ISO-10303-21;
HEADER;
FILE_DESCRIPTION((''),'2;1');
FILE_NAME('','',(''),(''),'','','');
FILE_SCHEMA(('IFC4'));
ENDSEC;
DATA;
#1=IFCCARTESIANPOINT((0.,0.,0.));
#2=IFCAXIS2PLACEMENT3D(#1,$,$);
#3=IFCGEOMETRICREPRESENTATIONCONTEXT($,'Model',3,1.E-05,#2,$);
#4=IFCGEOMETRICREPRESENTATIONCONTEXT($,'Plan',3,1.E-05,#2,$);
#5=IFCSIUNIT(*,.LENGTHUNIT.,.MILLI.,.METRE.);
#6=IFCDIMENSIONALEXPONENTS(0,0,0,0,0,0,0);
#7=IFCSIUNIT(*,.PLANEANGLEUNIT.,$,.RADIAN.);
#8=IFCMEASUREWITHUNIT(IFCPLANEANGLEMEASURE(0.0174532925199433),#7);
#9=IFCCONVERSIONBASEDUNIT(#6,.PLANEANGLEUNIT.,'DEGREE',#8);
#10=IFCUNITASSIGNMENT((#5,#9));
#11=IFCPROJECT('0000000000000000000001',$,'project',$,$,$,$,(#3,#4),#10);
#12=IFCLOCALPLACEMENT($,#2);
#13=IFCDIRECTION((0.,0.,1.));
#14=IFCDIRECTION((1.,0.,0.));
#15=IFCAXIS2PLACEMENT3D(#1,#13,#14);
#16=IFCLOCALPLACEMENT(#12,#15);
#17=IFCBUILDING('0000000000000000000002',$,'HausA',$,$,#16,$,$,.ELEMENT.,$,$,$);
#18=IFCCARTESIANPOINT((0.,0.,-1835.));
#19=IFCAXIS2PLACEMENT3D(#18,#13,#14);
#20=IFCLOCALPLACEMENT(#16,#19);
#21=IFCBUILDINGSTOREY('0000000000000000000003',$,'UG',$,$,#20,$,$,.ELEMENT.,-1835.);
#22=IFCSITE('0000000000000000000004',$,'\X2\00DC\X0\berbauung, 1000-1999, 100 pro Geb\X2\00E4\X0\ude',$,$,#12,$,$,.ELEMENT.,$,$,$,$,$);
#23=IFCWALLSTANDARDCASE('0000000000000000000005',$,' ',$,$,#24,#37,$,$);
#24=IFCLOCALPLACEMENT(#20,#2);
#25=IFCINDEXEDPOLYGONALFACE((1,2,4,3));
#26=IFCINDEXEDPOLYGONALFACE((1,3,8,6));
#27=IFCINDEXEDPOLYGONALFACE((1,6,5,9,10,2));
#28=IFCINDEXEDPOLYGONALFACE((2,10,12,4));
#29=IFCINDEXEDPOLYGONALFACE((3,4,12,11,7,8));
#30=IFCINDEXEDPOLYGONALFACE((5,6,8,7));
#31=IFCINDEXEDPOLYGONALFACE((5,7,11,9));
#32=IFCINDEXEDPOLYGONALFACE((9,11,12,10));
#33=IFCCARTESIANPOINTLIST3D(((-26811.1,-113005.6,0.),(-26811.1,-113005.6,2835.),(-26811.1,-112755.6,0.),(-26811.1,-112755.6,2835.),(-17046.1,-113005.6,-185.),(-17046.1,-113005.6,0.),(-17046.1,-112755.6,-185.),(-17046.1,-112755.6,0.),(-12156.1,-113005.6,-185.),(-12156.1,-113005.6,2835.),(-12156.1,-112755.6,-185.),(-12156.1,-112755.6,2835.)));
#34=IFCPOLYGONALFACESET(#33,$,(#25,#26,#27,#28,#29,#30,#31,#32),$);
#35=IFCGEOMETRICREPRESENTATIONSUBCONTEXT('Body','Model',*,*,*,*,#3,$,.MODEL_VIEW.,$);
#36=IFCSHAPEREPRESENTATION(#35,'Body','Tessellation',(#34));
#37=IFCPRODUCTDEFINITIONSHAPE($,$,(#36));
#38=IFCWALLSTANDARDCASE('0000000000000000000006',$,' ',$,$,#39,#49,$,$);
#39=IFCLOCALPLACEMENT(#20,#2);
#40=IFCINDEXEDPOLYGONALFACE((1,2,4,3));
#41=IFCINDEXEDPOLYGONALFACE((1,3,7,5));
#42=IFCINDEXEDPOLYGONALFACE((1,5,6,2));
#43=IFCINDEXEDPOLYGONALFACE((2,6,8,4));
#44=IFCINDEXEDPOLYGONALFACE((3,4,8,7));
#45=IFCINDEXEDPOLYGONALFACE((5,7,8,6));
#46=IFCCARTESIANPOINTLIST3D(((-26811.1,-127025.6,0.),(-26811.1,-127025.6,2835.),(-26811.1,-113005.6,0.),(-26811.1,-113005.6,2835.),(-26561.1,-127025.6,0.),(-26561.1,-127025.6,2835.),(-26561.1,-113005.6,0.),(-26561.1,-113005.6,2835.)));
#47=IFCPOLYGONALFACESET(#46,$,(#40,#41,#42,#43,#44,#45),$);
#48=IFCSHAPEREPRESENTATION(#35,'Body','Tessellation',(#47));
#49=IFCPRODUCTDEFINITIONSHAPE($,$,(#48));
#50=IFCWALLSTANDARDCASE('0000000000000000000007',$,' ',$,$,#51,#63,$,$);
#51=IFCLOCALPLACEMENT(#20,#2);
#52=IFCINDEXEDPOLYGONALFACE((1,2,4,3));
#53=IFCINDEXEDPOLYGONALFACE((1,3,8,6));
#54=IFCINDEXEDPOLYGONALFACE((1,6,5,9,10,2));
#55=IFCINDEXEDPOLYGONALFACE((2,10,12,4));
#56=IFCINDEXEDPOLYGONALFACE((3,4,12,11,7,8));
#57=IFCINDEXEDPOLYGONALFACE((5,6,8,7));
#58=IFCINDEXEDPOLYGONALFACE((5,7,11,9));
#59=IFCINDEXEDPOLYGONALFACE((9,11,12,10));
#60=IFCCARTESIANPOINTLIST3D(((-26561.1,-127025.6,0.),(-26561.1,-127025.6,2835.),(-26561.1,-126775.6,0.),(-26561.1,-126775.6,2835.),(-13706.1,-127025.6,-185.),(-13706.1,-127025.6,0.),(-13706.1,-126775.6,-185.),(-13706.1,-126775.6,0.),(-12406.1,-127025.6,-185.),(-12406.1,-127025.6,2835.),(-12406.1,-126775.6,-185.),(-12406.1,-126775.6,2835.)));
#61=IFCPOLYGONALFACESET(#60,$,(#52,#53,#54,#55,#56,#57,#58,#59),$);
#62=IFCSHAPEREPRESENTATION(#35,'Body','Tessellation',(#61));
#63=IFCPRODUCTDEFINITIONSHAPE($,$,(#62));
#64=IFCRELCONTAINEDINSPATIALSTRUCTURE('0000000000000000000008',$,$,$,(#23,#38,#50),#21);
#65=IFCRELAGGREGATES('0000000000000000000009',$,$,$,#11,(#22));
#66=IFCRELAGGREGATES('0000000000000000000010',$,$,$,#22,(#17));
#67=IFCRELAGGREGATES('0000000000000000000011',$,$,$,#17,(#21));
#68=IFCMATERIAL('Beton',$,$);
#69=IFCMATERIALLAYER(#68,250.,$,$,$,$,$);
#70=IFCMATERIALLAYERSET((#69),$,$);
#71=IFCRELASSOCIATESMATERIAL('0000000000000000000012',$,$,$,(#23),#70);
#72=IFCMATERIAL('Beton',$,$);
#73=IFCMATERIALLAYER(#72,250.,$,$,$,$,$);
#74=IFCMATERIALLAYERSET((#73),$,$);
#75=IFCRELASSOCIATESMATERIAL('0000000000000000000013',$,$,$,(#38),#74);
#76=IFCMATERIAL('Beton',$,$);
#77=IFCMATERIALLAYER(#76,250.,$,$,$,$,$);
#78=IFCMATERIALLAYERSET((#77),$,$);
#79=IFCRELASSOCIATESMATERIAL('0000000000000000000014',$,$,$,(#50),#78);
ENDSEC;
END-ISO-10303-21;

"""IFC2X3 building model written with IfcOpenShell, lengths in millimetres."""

from ifc_helpers import new_model, entity, si_unit, converted_unit, frame, frame_2d, origin, origin_with_axes, place, context, subcontext, project, spatial, polyline, rectangle, extrude, clip, bounded_halfspace, material, layer, layer_set, layer_usage, element, save


model = new_model("IFC2X3")

# Units and contexts
model_context = context("Model", 3, precision=1e-05, world=origin())
plan_context = context("Plan", 3, precision=1e-05, world=origin())
body_context = subcontext(model_context, "Body", "Model", "MODEL_VIEW")
ifc_project = project(units=[si_unit("LENGTHUNIT", "METRE", prefix="MILLI"), converted_unit("PLANEANGLEUNIT", "DEGREE", entity("IfcPlaneAngleMeasure", 0.0174532925199433), si_unit("PLANEANGLEUNIT", "RADIAN"), dimensions=[0, 0, 0, 0, 0, 0, 0])], contexts=[model_context, plan_context])

# Site, building, storey
site_placement = place(None, origin())
site = spatial("IfcSite", under=ifc_project, at=site_placement, Name="Überbauung, 1000-1999, 100 pro Gebäude", CompositionType="ELEMENT")
building_placement = place(site_placement, origin_with_axes())
building = spatial("IfcBuilding", under=site, at=building_placement, Name="HausA", CompositionType="ELEMENT")
storey_placement = place(building_placement, frame((0.0, 0.0, -1835.0), z_axis=(0.0, 0.0, 1.0), x_axis=(1.0, 0.0, 0.0)))
storey = spatial("IfcBuildingStorey", under=building, at=storey_placement, Name="UG", CompositionType="ELEMENT", Elevation=-1835.0)

# Walls
ifc_material_1 = material(Name="Beton")
ifc_layer_1 = layer(ifc_material_1, 250.0)
ifc_layer_set_1 = layer_set([ifc_layer_1])
ifc_layer_usage_1 = layer_usage(ifc_layer_set_1, "AXIS2", "POSITIVE", 0.0)
wall_1_placement = place(storey_placement, frame((-12156.1, -112755.6, -185.0), z_axis=(0.0, 0.0, 1.0), x_axis=(-1.0, 0.0, 0.0)))
element("IfcWallStandardCase", 1, at=wall_1_placement, inside=storey, material=ifc_layer_usage_1, Name=" ", context=body_context, shape_type="Clipping", body=[
    clip(clip(extrude(rectangle(XDim=14655.0, YDim=250.0, at=frame_2d((7327.5, 125.0), x_axis=(1.0, 0.0))), origin_with_axes(), (0.0, 0.0, 1.0), 3020.0), bounded_halfspace(frame((4890.0, 0.0, 0.0), z_axis=(0.0, 0.0, 1.0), x_axis=(0.0, 1.0, 0.0)), True, origin(), polyline([(4890.0, 0.0), (4890.0, 250.0), (0.0, 250.0), (0.0, 0.0), (4890.0, 0.0)]))), bounded_halfspace(frame((14655.0, 250.0, 185.0), z_axis=(0.0, 0.0, 1.0), x_axis=(-1.0, 0.0, 0.0)), True, origin(), polyline([(14655.0, 250.0), (4890.0, 250.0), (4890.0, 0.0), (14655.0, 0.0), (14655.0, 250.0)]))),
])
ifc_material_2 = material(Name="Beton")
ifc_layer_2 = layer(ifc_material_2, 250.0)
ifc_layer_set_2 = layer_set([ifc_layer_2])
ifc_layer_usage_2 = layer_usage(ifc_layer_set_2, "AXIS2", "POSITIVE", 0.0)
wall_2_placement = place(storey_placement, frame((-26811.1, -113005.6, 0.0), z_axis=(0.0, 0.0, 1.0), x_axis=(0.0, -1.0, 0.0)))
element("IfcWallStandardCase", 2, at=wall_2_placement, inside=storey, material=ifc_layer_usage_2, Name=" ", context=body_context, shape_type="SweptSolid", body=[
    extrude(rectangle(XDim=14020.0, YDim=250.0, at=frame_2d((7010.0, 125.0), x_axis=(1.0, 0.0))), origin_with_axes(), (0.0, 0.0, 1.0), 2835.0),
])
ifc_material_3 = material(Name="Beton")
ifc_layer_3 = layer(ifc_material_3, 250.0)
ifc_layer_set_3 = layer_set([ifc_layer_3])
ifc_layer_usage_3 = layer_usage(ifc_layer_set_3, "AXIS2", "POSITIVE", 0.0)
wall_3_placement = place(storey_placement, frame((-26561.1, -127025.6, -185.0), z_axis=(0.0, 0.0, 1.0), x_axis=(1.0, 0.0, 0.0)))
element("IfcWallStandardCase", 3, at=wall_3_placement, inside=storey, material=ifc_layer_usage_3, Name=" ", context=body_context, shape_type="Clipping", body=[
    clip(clip(extrude(rectangle(XDim=14155.0, YDim=250.0, at=frame_2d((7077.5, 125.0), x_axis=(1.0, 0.0))), origin_with_axes(), (0.0, 0.0, 1.0), 3020.0), bounded_halfspace(frame((12855.0, 250.0, 0.0), z_axis=(0.0, 0.0, 1.0), x_axis=(0.0, -1.0, 0.0)), True, origin(), polyline([(12855.0, 250.0), (12855.0, 0.0), (14155.0, 0.0), (14155.0, 250.0), (12855.0, 250.0)]))), bounded_halfspace(frame((0.0, 0.0, 185.0), z_axis=(0.0, 0.0, 1.0), x_axis=(1.0, 0.0, 0.0)), True, origin(), polyline([(0.0, 0.0), (12855.0, 0.0), (12855.0, 250.0), (0.0, 250.0), (0.0, 0.0)]))),
])

save(model, "model.ifc")
